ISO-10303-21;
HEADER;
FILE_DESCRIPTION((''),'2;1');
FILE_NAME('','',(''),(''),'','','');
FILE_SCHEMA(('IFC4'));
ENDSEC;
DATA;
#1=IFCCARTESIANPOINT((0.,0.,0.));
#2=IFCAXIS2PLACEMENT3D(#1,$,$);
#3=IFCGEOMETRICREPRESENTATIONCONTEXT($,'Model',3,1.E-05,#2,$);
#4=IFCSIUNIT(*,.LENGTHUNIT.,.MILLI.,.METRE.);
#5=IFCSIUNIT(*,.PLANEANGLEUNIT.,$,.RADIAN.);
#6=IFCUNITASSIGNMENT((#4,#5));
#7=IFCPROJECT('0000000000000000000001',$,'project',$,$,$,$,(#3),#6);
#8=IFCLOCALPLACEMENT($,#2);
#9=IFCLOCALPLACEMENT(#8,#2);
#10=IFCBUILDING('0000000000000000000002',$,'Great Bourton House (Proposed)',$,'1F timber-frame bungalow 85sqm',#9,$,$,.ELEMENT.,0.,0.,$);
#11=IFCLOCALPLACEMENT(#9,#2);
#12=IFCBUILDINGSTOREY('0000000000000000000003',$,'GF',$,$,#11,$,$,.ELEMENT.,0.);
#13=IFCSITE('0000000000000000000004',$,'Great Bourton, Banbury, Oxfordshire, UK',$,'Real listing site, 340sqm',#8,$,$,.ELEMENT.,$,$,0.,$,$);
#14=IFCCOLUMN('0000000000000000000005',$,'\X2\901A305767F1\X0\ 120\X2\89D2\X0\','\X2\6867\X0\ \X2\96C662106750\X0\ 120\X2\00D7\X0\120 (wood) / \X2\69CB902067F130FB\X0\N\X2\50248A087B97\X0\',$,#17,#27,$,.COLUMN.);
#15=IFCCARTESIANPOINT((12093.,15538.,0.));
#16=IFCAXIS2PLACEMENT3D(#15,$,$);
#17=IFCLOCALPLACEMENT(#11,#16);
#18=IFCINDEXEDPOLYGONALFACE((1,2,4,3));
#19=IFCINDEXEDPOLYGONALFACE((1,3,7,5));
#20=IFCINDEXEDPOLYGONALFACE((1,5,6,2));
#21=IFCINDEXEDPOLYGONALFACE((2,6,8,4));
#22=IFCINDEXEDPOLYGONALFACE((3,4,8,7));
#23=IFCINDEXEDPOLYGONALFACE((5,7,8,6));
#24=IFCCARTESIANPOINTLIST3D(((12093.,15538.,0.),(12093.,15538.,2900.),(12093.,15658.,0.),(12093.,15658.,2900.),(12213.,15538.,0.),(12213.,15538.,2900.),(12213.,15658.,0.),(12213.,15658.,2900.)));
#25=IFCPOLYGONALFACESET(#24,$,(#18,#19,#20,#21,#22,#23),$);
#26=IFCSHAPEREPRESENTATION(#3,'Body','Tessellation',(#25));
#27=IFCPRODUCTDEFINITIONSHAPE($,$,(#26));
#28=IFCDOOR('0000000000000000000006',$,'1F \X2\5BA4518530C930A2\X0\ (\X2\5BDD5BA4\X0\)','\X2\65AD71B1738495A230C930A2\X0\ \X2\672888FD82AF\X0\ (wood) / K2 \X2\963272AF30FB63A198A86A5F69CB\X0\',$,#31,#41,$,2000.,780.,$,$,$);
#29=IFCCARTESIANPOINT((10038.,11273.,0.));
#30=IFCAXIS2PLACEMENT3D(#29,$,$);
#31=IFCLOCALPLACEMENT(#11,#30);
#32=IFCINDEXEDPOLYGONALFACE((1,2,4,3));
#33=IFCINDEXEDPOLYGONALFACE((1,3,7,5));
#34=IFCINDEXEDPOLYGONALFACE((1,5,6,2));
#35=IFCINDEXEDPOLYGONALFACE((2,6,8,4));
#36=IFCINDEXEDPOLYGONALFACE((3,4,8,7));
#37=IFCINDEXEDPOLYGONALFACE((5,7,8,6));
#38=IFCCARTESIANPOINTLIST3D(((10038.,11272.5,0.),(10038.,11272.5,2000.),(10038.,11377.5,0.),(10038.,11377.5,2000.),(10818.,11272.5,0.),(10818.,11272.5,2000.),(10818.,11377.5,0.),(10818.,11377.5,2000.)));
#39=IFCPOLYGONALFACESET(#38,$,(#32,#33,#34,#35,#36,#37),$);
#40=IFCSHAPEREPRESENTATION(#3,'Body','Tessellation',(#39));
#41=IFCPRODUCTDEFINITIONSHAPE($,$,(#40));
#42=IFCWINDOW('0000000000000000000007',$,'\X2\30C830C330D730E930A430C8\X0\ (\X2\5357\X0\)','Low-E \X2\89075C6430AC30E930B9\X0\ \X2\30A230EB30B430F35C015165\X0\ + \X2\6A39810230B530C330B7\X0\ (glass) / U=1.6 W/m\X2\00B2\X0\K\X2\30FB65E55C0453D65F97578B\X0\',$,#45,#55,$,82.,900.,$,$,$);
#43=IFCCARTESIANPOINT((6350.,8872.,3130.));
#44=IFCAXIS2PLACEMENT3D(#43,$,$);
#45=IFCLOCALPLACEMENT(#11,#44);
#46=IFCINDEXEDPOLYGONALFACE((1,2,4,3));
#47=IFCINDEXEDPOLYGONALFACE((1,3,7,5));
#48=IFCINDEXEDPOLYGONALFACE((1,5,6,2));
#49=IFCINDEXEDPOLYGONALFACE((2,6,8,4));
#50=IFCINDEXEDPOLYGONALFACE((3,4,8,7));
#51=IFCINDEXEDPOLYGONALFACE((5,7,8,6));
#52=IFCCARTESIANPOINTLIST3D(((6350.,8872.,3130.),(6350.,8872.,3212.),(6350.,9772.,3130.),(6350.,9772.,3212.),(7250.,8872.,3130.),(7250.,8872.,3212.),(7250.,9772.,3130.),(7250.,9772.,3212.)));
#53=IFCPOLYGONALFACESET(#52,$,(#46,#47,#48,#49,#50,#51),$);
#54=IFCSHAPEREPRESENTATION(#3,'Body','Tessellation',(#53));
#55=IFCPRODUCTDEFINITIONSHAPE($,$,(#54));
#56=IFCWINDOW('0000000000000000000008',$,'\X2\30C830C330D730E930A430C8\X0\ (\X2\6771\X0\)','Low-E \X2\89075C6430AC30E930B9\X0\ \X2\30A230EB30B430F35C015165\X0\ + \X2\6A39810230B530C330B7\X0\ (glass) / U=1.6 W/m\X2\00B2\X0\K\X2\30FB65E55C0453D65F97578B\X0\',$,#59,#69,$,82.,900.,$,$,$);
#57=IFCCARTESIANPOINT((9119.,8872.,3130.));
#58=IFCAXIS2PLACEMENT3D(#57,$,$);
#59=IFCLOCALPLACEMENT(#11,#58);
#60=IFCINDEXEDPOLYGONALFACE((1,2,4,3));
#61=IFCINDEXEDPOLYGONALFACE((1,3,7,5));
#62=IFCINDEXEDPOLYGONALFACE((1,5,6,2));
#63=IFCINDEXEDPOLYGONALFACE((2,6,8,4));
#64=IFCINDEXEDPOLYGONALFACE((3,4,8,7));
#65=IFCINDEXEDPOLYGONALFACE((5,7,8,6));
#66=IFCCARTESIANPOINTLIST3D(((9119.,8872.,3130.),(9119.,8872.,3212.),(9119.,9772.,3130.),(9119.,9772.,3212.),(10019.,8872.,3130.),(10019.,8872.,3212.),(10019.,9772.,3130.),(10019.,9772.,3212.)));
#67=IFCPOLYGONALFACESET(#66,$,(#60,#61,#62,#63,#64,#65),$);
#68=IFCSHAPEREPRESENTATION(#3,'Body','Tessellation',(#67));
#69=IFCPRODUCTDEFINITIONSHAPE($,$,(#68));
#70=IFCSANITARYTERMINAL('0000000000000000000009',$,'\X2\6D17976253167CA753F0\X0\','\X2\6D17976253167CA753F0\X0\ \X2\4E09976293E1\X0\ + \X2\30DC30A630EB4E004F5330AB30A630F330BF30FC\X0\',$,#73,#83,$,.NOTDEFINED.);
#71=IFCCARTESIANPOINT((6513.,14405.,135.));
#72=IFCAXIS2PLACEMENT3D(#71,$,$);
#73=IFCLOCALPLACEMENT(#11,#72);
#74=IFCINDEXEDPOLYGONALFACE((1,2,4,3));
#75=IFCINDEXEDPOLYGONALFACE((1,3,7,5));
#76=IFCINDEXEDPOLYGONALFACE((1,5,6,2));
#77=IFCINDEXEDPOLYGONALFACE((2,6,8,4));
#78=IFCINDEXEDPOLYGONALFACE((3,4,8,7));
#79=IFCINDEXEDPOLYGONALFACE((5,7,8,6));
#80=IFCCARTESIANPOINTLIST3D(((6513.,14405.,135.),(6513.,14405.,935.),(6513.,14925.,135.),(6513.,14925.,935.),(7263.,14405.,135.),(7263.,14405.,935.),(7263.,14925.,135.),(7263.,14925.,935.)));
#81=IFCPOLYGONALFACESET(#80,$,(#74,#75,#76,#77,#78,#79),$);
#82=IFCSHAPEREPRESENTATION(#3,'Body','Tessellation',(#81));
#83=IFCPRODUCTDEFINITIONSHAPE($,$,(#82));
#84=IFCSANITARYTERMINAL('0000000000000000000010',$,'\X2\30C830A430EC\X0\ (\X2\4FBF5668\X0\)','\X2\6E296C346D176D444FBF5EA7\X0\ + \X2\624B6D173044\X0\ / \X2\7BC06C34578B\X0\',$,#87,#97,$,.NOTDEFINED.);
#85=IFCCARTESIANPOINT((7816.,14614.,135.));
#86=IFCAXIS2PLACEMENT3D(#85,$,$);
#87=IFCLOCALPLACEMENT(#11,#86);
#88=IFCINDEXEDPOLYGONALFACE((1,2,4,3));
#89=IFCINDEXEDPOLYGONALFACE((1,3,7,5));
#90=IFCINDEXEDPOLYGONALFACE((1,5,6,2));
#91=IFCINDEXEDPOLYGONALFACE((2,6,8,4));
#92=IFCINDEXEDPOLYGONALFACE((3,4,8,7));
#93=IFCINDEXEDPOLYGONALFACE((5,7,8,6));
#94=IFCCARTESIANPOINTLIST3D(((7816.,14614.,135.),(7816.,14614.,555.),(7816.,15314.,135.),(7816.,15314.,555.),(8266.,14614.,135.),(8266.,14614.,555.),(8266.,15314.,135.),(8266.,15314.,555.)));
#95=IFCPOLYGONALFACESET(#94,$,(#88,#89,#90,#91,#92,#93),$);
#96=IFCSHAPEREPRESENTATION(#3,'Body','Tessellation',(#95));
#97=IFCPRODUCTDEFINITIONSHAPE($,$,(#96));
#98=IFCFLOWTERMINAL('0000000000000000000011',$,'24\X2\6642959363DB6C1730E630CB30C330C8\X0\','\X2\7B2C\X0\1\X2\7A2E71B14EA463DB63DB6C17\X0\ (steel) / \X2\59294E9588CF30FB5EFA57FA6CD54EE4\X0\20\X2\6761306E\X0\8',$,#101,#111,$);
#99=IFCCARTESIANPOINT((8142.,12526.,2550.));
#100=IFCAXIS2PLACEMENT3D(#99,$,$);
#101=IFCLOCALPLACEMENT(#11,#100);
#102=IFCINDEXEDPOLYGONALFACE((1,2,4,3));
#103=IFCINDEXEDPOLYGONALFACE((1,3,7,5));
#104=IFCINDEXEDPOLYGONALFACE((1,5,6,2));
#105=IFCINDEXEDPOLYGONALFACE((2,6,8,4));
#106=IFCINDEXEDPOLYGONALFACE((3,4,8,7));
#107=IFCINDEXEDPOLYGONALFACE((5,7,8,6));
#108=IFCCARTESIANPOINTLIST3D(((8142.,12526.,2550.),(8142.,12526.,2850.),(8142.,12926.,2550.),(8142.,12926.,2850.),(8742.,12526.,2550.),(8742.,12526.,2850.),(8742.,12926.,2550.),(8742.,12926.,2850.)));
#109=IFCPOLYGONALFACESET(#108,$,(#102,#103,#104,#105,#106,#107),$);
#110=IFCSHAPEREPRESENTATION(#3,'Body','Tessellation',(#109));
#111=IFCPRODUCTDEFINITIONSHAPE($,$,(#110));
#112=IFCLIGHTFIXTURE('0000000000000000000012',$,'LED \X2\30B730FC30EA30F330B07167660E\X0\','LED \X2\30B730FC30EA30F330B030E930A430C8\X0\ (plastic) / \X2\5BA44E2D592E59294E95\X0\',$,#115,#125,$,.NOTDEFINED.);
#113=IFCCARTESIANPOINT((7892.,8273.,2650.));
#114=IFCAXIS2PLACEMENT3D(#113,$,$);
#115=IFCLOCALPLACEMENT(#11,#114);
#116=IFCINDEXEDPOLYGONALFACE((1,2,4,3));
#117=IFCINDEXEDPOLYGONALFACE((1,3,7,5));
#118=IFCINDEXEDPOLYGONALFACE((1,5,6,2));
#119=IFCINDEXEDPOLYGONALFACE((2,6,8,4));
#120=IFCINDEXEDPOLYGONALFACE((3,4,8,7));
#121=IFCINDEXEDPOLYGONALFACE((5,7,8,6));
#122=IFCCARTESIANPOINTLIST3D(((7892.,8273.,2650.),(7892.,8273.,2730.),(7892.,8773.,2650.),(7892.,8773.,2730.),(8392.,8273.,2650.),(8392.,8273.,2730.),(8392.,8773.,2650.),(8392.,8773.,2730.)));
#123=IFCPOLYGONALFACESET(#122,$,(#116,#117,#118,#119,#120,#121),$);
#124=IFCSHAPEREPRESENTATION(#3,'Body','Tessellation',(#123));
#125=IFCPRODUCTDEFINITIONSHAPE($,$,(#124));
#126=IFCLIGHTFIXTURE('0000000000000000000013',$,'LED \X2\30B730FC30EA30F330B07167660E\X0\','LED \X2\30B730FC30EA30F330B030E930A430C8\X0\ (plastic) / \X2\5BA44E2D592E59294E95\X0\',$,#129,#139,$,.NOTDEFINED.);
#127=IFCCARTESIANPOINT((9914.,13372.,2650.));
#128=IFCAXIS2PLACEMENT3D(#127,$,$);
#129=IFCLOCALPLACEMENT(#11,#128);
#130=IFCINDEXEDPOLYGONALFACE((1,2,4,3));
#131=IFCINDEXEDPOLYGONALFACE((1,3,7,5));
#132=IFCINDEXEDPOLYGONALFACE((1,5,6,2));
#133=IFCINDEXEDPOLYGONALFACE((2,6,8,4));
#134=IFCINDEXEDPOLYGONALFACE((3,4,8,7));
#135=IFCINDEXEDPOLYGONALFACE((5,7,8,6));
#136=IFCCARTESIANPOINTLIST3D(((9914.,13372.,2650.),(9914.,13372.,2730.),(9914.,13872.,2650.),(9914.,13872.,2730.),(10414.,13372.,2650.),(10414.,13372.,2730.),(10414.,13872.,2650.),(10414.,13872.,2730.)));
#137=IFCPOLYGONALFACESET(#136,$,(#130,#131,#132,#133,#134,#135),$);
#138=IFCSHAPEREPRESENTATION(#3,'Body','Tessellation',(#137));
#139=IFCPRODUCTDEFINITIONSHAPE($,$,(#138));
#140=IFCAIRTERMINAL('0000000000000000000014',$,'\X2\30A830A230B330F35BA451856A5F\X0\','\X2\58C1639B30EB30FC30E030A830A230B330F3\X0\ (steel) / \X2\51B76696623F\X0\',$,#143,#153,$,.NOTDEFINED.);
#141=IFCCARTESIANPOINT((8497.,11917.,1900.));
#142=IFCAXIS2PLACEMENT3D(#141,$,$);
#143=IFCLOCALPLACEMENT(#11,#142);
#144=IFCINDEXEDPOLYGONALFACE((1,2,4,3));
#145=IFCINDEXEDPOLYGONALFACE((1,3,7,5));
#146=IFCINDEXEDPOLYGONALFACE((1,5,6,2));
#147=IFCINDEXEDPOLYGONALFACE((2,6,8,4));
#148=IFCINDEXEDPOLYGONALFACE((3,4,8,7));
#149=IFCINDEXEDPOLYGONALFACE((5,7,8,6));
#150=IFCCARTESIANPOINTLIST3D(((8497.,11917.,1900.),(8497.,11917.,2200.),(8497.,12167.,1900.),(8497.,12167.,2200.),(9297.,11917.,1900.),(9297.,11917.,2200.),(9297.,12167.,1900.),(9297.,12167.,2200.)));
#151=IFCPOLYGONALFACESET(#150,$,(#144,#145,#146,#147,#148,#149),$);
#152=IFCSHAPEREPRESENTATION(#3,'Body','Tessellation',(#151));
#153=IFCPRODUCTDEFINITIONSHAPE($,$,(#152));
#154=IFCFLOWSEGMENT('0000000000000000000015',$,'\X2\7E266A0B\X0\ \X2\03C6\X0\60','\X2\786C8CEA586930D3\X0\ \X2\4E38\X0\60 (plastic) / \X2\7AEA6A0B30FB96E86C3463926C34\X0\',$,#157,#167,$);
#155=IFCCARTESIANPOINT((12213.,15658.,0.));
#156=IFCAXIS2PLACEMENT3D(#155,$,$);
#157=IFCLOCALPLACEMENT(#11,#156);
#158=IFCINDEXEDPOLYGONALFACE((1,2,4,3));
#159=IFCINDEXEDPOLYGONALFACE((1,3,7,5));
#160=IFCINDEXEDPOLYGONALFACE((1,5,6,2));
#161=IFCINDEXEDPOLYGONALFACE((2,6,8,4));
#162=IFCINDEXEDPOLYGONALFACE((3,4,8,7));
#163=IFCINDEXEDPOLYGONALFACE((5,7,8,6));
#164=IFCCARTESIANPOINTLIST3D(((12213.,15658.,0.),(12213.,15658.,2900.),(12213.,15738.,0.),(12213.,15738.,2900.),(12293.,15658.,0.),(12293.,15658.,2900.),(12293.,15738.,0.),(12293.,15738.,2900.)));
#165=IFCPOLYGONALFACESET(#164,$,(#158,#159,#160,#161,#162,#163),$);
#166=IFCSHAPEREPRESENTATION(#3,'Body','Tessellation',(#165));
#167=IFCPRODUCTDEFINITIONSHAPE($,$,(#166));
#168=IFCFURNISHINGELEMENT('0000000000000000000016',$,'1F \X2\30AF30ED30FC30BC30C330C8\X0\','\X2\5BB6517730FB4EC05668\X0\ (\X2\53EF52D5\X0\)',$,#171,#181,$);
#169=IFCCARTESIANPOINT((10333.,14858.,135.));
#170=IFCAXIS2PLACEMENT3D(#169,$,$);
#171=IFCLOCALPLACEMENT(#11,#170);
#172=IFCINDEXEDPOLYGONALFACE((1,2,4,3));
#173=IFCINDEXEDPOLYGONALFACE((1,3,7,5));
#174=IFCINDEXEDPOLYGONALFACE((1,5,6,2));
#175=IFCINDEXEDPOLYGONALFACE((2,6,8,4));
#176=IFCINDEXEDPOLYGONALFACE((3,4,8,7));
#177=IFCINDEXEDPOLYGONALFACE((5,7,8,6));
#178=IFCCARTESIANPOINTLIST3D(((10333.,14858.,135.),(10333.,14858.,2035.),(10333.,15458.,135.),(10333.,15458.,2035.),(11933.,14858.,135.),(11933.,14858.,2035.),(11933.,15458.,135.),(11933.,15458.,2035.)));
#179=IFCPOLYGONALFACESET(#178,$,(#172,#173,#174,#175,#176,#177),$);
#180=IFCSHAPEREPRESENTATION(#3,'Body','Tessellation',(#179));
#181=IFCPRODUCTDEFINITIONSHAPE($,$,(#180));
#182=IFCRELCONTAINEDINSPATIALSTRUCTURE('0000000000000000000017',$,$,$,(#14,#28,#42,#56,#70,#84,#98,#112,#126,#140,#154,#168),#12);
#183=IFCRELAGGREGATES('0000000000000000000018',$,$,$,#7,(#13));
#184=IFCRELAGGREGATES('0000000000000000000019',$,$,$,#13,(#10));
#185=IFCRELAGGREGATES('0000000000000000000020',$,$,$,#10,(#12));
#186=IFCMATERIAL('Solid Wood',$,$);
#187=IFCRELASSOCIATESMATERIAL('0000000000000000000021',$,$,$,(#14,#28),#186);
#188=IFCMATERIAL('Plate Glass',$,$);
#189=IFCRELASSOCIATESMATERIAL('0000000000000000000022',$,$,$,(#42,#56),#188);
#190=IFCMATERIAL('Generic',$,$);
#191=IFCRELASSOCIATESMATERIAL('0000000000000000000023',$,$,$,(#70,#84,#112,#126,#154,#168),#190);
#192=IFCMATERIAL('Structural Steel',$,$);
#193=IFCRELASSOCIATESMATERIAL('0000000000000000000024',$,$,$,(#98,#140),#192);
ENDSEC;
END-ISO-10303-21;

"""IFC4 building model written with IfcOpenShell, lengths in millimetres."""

from ifc_helpers import new_model, si_unit, frame, frame_2d, origin, place, context, project, spatial, rectangle, extrude, material, element, save


model = new_model("IFC4")

# Units and contexts
model_context = context("Model", 3, precision=1e-05, world=origin())
ifc_project = project(units=[si_unit("LENGTHUNIT", "METRE", prefix="MILLI"), si_unit("PLANEANGLEUNIT", "RADIAN")], contexts=[model_context])

# Site, building, storey
site_placement = place(None, origin())
site = spatial("IfcSite", under=ifc_project, at=site_placement, Name="Great Bourton, Banbury, Oxfordshire, UK", ObjectType="Real listing site, 340sqm", CompositionType="ELEMENT", RefElevation=0.0)
building_placement = place(site_placement, origin())
building = spatial("IfcBuilding", under=site, at=building_placement, Name="Great Bourton House (Proposed)", ObjectType="1F timber-frame bungalow 85sqm", CompositionType="ELEMENT", ElevationOfRefHeight=0.0, ElevationOfTerrain=0.0)
storey_placement = place(building_placement, origin())
storey = spatial("IfcBuildingStorey", under=building, at=storey_placement, Name="GF", CompositionType="ELEMENT", Elevation=0.0)

# Column
ifc_material_1 = material(Name="Solid Wood")
column_1_placement = place(storey_placement, frame((12093.0, 15538.0, 0.0)))
element("IfcColumn", 1, at=column_1_placement, inside=storey, material=ifc_material_1, Name="通し柱 120角", Description="桧 集成材 120×120 (wood) / 構造柱・N値計算", PredefinedType="COLUMN", context=model_context, shape_type="SweptSolid", body=[
    extrude(rectangle(XDim=120.0, YDim=120.0, at=frame_2d((60.0, 60.0))), frame((12093.0, 15538.0, 0.0)), (0.0, 0.0, 1.0), 2900.0),
])

# Door
door_placement = place(storey_placement, frame((10038.0, 11273.0, 0.0)))
element("IfcDoor", 2, at=door_placement, inside=storey, material=ifc_material_1, Name="1F 室内ドア (寝室)", Description="断熱玄関ドア 木製芯 (wood) / K2 防犯・採風機構", OverallHeight=2000.0, OverallWidth=780.0, context=model_context, shape_type="SweptSolid", body=[
    extrude(rectangle(XDim=780.0, YDim=105.0, at=frame_2d((390.0, 52.0))), frame((10038.0, 11273.0, 0.0)), (0.0, 0.0, 1.0), 2000.0),
])

# Windows
ifc_material_2 = material(Name="Plate Glass")
window_1_placement = place(storey_placement, frame((6350.0, 8872.0, 3130.0)))
element("IfcWindow", 3, at=window_1_placement, inside=storey, material=ifc_material_2, Name="トップライト (南)", Description="Low-E 複層ガラス アルゴン封入 + 樹脂サッシ (glass) / U=1.6 W/m²K・日射取得型", OverallHeight=82.0, OverallWidth=900.0, context=model_context, shape_type="SweptSolid", body=[
    extrude(rectangle(XDim=900.0, YDim=900.0, at=frame_2d((450.0, 450.0))), frame((6350.0, 8872.0, 3130.0)), (0.0, 0.0, 1.0), 82.0),
])
window_2_placement = place(storey_placement, frame((9119.0, 8872.0, 3130.0)))
element("IfcWindow", 4, at=window_2_placement, inside=storey, material=ifc_material_2, Name="トップライト (東)", Description="Low-E 複層ガラス アルゴン封入 + 樹脂サッシ (glass) / U=1.6 W/m²K・日射取得型", OverallHeight=82.0, OverallWidth=900.0, context=model_context, shape_type="SweptSolid", body=[
    extrude(rectangle(XDim=900.0, YDim=900.0, at=frame_2d((450.0, 450.0))), frame((9119.0, 8872.0, 3130.0)), (0.0, 0.0, 1.0), 82.0),
])

# Sanitary terminals
ifc_material_3 = material(Name="Generic")
sanitary_terminal_1_placement = place(storey_placement, frame((6513.0, 14405.0, 135.0)))
element("IfcSanitaryTerminal", 5, at=sanitary_terminal_1_placement, inside=storey, material=ifc_material_3, Name="洗面化粧台", Description="洗面化粧台 三面鏡 + ボウル一体カウンター", PredefinedType="NOTDEFINED", context=model_context, shape_type="SweptSolid", body=[
    extrude(rectangle(XDim=750.0, YDim=520.0, at=frame_2d((375.0, 260.0))), frame((6513.0, 14405.0, 135.0)), (0.0, 0.0, 1.0), 800.0),
])
sanitary_terminal_2_placement = place(storey_placement, frame((7816.0, 14614.0, 135.0)))
element("IfcSanitaryTerminal", 6, at=sanitary_terminal_2_placement, inside=storey, material=ifc_material_3, Name="トイレ (便器)", Description="温水洗浄便座 + 手洗い / 節水型", PredefinedType="NOTDEFINED", context=model_context, shape_type="SweptSolid", body=[
    extrude(rectangle(XDim=450.0, YDim=700.0, at=frame_2d((225.0, 350.0))), frame((7816.0, 14614.0, 135.0)), (0.0, 0.0, 1.0), 420.0),
])

# Flow terminal
ifc_material_4 = material(Name="Structural Steel")
flow_terminal_placement = place(storey_placement, frame((8142.0, 12526.0, 2550.0)))
element("IfcFlowTerminal", 7, at=flow_terminal_placement, inside=storey, material=ifc_material_4, Name="24時間換気ユニット", Description="第1種熱交換換気 (steel) / 天井裏・建基法令20条の8", context=model_context, shape_type="SweptSolid", body=[
    extrude(rectangle(XDim=600.0, YDim=400.0, at=frame_2d((300.0, 200.0))), frame((8142.0, 12526.0, 2550.0)), (0.0, 0.0, 1.0), 300.0),
])

# Light fixtures
light_fixture_1_placement = place(storey_placement, frame((7892.0, 8273.0, 2650.0)))
element("IfcLightFixture", 8, at=light_fixture_1_placement, inside=storey, material=ifc_material_3, Name="LED シーリング照明", Description="LED シーリングライト (plastic) / 室中央天井", PredefinedType="NOTDEFINED", context=model_context, shape_type="SweptSolid", body=[
    extrude(rectangle(XDim=500.0, YDim=500.0, at=frame_2d((250.0, 250.0))), frame((7892.0, 8273.0, 2650.0)), (0.0, 0.0, 1.0), 80.0),
])
light_fixture_2_placement = place(storey_placement, frame((9914.0, 13372.0, 2650.0)))
element("IfcLightFixture", 9, at=light_fixture_2_placement, inside=storey, material=ifc_material_3, Name="LED シーリング照明", Description="LED シーリングライト (plastic) / 室中央天井", PredefinedType="NOTDEFINED", context=model_context, shape_type="SweptSolid", body=[
    extrude(rectangle(XDim=500.0, YDim=500.0, at=frame_2d((250.0, 250.0))), frame((9914.0, 13372.0, 2650.0)), (0.0, 0.0, 1.0), 80.0),
])

# Air terminal
air_terminal_placement = place(storey_placement, frame((8497.0, 11917.0, 1900.0)))
element("IfcAirTerminal", 10, at=air_terminal_placement, inside=storey, material=ifc_material_4, Name="エアコン室内機", Description="壁掛ルームエアコン (steel) / 冷暖房", PredefinedType="NOTDEFINED", context=model_context, shape_type="SweptSolid", body=[
    extrude(rectangle(XDim=800.0, YDim=250.0, at=frame_2d((400.0, 125.0))), frame((8497.0, 11917.0, 1900.0)), (0.0, 0.0, 1.0), 300.0),
])

# Flow segment
flow_segment_placement = place(storey_placement, frame((12213.0, 15658.0, 0.0)))
element("IfcFlowSegment", 11, at=flow_segment_placement, inside=storey, material=ifc_material_3, Name="縦樋 φ60", Description="硬質塩ビ 丸60 (plastic) / 竪樋・雨水排水", context=model_context, shape_type="SweptSolid", body=[
    extrude(rectangle(XDim=80.0, YDim=80.0, at=frame_2d((40.0, 40.0))), frame((12213.0, 15658.0, 0.0)), (0.0, 0.0, 1.0), 2900.0),
])

# Furnishing element
furnishing_placement = place(storey_placement, frame((10333.0, 14858.0, 135.0)))
element("IfcFurnishingElement", 12, at=furnishing_placement, inside=storey, material=ifc_material_3, Name="1F クローゼット", Description="家具・什器 (可動)", context=model_context, shape_type="SweptSolid", body=[
    extrude(rectangle(XDim=1600.0, YDim=600.0, at=frame_2d((800.0, 300.0))), frame((10333.0, 14858.0, 135.0)), (0.0, 0.0, 1.0), 1900.0),
])

save(model, "model.ifc")
